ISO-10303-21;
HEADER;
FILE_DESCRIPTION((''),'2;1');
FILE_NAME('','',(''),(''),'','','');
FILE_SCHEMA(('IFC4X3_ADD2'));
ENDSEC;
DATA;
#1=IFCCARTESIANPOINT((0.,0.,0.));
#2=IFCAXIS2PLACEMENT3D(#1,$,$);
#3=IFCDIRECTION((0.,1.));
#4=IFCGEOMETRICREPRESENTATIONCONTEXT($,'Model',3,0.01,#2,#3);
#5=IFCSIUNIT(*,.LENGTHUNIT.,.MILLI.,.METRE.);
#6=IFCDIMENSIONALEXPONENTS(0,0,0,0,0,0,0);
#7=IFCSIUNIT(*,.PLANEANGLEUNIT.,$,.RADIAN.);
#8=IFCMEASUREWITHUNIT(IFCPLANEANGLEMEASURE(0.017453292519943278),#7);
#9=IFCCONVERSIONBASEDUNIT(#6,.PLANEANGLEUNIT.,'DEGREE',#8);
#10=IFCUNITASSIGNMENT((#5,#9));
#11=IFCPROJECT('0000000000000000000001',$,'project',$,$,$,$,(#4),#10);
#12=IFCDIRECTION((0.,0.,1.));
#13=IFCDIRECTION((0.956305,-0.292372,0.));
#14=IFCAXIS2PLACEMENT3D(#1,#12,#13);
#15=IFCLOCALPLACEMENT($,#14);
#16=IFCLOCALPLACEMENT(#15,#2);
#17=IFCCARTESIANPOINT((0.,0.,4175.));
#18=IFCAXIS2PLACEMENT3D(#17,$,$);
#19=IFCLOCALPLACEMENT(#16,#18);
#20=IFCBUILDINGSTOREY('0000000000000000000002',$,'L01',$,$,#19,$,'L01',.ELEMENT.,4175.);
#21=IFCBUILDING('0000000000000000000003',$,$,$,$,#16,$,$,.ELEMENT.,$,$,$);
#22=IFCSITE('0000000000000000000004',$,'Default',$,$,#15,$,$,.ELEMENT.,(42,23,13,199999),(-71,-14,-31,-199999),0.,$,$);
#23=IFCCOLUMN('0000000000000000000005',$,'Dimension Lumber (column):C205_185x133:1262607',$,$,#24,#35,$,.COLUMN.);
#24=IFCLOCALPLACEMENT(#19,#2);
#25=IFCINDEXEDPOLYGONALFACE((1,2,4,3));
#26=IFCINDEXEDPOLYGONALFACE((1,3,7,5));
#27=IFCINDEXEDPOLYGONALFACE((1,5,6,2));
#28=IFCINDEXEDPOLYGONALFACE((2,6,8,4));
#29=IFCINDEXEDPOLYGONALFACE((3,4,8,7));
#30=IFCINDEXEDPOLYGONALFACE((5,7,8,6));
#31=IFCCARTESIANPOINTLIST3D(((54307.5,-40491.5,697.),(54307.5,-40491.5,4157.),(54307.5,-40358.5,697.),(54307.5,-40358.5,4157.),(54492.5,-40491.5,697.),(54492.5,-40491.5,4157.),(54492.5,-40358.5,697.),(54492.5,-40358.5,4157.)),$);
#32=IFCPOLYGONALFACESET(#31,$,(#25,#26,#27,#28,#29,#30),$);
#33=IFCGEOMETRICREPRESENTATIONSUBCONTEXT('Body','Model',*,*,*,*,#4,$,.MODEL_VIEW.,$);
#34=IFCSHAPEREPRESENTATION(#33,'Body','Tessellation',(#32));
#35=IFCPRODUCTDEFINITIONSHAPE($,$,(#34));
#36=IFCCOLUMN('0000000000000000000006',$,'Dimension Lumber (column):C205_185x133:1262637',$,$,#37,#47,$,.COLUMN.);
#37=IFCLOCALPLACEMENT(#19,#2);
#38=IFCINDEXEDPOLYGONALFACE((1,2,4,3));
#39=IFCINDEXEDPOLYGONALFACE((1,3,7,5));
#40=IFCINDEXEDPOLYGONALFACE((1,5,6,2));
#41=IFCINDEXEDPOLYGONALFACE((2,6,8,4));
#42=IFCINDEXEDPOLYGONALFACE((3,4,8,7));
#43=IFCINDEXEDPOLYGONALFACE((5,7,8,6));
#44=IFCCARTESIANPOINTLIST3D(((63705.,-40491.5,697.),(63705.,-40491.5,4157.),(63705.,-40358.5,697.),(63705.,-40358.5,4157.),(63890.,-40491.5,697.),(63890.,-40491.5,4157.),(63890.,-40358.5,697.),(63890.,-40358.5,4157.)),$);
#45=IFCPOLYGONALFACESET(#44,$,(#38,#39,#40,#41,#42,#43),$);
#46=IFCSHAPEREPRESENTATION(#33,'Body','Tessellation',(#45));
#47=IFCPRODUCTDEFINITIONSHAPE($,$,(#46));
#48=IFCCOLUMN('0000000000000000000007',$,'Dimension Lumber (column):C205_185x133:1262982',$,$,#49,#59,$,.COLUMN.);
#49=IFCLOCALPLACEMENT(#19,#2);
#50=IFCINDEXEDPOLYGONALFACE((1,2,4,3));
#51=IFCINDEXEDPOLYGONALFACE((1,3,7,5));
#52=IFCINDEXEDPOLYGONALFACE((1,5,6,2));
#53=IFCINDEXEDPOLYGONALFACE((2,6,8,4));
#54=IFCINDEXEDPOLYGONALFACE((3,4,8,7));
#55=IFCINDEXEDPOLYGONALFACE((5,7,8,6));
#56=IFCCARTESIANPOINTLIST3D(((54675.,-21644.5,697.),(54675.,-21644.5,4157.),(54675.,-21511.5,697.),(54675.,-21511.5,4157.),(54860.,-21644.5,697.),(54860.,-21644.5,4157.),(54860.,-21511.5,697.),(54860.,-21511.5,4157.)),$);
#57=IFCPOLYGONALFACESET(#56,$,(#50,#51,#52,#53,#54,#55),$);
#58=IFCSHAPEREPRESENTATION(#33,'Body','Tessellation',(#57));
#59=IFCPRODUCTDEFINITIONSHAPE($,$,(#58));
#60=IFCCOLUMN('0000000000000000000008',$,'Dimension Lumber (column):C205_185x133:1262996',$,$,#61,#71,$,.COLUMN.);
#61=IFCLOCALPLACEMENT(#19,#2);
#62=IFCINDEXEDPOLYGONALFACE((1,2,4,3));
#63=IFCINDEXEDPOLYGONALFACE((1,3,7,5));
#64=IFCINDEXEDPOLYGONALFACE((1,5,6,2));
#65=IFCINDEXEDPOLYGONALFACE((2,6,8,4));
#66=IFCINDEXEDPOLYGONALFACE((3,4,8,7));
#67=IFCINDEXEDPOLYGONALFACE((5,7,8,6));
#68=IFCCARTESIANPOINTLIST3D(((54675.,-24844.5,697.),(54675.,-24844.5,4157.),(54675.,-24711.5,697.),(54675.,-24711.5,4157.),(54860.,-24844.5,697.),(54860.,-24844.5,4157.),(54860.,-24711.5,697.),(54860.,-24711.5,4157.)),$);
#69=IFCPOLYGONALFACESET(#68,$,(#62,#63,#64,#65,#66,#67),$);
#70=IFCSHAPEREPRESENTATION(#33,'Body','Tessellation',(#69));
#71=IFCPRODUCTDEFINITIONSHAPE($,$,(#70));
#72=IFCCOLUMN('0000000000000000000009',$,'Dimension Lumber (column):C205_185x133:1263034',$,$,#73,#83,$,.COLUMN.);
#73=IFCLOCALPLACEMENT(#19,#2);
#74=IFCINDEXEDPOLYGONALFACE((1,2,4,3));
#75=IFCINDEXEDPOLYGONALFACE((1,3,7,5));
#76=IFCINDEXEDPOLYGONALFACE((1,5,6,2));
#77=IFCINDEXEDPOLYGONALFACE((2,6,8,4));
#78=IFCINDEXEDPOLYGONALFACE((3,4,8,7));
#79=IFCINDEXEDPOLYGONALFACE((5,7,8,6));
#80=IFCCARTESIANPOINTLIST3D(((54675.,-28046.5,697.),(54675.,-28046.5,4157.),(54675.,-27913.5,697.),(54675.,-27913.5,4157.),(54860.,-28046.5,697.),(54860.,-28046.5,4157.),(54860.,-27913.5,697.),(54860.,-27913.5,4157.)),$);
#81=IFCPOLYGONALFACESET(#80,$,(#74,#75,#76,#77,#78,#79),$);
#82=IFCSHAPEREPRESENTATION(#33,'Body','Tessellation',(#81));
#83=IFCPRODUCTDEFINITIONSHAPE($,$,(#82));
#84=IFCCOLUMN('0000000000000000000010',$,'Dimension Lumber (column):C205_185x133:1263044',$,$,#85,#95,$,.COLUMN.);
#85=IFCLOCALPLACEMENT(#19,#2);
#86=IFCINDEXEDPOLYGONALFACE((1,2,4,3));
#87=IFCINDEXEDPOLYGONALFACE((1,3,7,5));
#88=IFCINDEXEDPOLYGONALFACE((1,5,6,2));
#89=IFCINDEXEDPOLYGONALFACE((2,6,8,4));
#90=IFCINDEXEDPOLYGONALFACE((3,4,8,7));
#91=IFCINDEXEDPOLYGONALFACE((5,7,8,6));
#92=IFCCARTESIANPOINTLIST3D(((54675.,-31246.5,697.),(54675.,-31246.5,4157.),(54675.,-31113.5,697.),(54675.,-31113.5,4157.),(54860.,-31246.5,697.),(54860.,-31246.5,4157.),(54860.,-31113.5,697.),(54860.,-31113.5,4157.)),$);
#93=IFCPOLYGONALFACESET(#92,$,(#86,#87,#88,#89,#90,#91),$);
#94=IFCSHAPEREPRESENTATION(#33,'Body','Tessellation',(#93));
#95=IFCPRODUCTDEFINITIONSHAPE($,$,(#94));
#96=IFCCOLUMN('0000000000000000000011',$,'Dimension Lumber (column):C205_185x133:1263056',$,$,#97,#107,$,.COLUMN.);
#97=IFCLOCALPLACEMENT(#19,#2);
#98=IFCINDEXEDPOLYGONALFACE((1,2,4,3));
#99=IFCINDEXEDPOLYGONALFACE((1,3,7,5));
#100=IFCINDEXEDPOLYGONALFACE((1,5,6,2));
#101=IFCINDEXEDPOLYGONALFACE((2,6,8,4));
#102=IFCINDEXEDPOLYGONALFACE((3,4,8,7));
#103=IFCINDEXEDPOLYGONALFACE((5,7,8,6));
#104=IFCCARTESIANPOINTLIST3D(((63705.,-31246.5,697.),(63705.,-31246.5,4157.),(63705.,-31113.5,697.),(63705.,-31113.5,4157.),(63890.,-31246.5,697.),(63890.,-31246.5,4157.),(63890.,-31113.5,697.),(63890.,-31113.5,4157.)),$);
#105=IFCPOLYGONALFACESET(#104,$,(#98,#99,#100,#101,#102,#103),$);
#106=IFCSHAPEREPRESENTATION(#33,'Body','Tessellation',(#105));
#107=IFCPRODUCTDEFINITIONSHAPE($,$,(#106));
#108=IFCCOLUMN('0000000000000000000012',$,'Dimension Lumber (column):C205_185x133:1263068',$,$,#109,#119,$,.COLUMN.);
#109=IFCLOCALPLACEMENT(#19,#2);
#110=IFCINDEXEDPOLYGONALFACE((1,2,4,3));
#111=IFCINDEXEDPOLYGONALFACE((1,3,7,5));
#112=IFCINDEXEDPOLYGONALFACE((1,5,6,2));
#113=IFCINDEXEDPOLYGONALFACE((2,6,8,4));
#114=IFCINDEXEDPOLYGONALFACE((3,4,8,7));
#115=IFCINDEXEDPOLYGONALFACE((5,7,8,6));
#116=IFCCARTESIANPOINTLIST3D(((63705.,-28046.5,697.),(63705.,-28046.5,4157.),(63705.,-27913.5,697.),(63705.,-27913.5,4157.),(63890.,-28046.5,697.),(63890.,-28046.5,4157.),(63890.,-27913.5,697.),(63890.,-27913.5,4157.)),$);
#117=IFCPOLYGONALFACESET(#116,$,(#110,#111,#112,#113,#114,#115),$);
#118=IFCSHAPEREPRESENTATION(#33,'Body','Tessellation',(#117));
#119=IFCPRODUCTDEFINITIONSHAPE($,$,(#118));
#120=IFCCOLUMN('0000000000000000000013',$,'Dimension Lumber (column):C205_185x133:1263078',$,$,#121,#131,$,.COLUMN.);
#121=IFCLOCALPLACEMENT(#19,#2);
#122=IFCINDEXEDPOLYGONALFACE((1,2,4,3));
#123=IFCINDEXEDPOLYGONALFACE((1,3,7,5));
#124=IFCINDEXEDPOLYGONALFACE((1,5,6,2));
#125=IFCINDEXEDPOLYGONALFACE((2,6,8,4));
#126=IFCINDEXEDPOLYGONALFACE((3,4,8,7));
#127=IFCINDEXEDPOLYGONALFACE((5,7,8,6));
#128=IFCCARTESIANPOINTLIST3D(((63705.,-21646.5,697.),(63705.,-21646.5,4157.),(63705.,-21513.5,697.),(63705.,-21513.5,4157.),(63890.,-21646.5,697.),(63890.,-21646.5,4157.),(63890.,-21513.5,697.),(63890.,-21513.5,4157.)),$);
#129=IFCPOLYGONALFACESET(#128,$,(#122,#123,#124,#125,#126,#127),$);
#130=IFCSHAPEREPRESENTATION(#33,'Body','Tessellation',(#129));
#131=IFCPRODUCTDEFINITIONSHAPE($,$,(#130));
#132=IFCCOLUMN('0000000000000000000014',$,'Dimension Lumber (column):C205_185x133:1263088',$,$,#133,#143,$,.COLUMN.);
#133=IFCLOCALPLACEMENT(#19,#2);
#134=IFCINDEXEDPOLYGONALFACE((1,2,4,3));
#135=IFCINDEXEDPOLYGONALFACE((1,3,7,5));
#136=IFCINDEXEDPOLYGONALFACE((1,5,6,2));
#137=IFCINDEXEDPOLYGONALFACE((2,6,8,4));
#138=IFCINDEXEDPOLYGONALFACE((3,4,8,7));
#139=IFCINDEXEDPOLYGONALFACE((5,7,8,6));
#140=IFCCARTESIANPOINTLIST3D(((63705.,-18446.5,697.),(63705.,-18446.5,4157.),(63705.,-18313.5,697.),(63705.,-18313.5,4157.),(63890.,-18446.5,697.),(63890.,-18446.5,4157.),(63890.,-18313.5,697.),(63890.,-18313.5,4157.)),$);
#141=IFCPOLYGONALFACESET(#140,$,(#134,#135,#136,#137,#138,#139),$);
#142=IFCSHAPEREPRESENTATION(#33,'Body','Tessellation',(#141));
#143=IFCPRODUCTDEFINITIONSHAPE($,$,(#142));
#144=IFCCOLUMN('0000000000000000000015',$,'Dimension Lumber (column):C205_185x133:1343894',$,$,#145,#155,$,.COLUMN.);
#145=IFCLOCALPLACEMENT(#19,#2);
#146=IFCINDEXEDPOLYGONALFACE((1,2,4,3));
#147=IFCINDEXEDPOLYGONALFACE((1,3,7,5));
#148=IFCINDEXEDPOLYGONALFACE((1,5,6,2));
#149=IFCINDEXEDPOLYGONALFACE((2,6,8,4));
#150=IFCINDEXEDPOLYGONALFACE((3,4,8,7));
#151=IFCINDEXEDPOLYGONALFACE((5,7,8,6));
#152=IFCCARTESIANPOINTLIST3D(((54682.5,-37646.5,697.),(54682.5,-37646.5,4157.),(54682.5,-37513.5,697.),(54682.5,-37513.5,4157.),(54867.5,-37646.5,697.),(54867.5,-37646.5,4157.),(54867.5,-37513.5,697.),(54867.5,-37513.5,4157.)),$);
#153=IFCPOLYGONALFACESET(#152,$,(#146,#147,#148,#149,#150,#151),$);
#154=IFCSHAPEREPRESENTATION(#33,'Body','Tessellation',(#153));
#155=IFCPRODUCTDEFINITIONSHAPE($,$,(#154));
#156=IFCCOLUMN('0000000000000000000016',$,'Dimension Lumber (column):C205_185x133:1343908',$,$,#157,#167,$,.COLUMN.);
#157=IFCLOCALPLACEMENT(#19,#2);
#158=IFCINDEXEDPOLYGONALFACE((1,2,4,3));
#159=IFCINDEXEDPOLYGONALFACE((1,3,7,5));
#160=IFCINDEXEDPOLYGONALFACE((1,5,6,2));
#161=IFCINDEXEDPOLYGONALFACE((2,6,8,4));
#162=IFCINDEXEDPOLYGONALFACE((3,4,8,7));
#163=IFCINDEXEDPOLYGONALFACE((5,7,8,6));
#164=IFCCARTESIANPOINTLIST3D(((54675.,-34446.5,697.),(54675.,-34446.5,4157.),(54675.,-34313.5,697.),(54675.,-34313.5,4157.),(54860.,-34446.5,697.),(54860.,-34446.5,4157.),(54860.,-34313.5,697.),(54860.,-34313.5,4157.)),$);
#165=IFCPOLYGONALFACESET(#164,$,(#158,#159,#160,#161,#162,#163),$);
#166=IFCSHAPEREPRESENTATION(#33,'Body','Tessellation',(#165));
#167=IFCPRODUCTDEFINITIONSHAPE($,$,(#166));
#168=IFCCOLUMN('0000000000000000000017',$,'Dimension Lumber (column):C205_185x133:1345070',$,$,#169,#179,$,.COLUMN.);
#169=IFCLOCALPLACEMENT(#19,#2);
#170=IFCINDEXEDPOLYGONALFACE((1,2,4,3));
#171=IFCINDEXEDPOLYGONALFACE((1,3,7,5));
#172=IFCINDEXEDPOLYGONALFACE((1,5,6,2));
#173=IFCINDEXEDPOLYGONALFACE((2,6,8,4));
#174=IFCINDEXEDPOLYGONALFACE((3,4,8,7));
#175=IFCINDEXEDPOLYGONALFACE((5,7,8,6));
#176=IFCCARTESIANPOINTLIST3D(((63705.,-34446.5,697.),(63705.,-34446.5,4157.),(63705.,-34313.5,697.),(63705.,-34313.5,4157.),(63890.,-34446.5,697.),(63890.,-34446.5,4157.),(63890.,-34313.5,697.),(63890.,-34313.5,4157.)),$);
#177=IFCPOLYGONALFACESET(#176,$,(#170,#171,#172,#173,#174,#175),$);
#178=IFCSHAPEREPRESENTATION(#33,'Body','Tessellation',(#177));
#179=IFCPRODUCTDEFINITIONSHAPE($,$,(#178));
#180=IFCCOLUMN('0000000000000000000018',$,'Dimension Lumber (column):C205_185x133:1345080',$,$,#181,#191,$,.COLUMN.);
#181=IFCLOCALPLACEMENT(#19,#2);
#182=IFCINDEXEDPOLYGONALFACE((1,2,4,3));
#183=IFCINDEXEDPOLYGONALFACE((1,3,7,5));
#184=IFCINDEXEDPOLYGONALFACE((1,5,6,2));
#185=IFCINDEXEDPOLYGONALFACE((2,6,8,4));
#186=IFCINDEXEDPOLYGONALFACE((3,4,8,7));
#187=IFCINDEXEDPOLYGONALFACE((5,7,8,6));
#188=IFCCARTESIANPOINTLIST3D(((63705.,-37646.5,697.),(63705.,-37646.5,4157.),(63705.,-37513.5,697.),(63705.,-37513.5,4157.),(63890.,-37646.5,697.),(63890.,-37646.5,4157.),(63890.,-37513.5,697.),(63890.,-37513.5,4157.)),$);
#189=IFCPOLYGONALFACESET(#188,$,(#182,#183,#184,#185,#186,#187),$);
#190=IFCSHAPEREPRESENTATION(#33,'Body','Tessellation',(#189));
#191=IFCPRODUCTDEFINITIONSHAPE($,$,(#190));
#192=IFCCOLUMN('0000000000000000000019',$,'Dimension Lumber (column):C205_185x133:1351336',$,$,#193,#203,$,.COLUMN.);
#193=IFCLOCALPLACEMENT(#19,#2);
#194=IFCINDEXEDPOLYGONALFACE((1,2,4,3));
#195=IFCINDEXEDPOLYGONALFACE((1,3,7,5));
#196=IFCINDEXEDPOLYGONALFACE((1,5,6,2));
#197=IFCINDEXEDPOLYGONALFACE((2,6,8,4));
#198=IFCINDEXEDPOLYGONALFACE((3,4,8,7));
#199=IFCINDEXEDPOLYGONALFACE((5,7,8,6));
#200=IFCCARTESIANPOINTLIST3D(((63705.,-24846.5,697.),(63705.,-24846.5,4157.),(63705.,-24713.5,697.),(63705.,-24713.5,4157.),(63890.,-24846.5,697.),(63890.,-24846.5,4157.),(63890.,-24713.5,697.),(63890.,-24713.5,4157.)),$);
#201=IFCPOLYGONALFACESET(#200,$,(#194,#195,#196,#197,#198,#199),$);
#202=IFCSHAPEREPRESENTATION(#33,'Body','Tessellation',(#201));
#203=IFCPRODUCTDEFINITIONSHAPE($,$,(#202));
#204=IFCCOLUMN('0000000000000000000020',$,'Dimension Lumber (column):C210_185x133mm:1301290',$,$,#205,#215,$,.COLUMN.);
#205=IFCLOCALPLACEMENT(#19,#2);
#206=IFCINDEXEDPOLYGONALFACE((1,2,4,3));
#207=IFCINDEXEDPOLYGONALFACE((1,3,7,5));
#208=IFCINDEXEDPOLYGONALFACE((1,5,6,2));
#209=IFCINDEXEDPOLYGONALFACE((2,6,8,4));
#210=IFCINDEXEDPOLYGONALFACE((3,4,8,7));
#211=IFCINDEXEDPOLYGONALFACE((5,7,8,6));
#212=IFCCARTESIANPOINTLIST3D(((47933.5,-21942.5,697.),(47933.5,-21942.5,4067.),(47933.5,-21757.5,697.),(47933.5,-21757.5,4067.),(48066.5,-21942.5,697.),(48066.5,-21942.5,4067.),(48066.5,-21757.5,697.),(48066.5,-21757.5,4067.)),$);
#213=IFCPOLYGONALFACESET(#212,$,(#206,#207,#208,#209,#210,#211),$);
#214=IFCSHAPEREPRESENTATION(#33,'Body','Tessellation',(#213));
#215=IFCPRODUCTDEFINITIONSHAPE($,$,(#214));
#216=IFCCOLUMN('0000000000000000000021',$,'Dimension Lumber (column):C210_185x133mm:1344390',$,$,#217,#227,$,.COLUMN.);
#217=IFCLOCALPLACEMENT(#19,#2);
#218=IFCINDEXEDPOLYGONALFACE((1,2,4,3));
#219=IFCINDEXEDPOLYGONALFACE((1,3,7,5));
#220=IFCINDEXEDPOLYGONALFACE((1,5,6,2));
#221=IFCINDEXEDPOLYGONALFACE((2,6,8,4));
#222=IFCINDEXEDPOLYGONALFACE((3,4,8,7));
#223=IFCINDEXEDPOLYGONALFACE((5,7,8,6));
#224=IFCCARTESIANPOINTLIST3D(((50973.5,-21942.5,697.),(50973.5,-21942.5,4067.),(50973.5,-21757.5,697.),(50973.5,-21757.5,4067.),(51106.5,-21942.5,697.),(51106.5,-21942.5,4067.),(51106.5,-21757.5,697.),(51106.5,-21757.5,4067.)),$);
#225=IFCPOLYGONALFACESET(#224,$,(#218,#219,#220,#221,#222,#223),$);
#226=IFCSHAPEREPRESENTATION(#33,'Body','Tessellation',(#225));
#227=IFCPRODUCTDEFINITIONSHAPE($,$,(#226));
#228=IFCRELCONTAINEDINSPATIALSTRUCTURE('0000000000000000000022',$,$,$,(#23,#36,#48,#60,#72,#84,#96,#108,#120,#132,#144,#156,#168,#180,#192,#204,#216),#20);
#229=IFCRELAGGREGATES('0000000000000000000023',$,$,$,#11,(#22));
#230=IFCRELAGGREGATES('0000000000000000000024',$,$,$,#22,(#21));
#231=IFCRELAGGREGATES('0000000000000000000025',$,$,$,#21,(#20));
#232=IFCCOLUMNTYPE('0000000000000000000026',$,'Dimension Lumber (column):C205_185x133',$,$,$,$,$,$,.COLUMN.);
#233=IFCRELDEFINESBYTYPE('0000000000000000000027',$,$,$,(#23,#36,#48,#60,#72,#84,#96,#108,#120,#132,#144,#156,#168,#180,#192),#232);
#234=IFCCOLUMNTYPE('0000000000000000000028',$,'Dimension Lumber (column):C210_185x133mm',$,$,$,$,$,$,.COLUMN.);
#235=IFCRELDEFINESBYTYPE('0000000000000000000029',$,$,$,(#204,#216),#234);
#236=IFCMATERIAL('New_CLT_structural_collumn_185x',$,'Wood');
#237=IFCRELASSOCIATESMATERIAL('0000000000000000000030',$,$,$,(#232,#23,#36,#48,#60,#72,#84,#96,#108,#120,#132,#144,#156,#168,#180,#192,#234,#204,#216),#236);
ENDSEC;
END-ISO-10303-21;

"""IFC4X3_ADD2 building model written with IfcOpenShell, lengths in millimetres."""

from ifc_helpers import new_model, entity, si_unit, converted_unit, direction, frame, origin, origin_2d_with_axis, place, context, subcontext, project, spatial, rectangle, extrude, source, transform, mapped, material, material_profile, profile_set, profile_usage, type_object, type_shapes, element, save


model = new_model("IFC4X3_ADD2")

# Units and contexts
model_context = context("Model", 3, precision=0.01, world=origin(), true_north=direction((0.0, 1.0)))
body_context = subcontext(model_context, "Body", "Model", "MODEL_VIEW")
ifc_project = project(units=[si_unit("LENGTHUNIT", "METRE", prefix="MILLI"), converted_unit("PLANEANGLEUNIT", "DEGREE", entity("IfcPlaneAngleMeasure", 0.017453292519943278), si_unit("PLANEANGLEUNIT", "RADIAN"), dimensions=[0, 0, 0, 0, 0, 0, 0])], contexts=[model_context])

# Site, building, storey
site_placement = place(None, frame((0.0, 0.0, 0.0), z_axis=(0.0, 0.0, 1.0), x_axis=(0.956305, -0.292372, 0.0)))
site = spatial("IfcSite", under=ifc_project, at=site_placement, Name="Default", CompositionType="ELEMENT", RefLatitude=(42, 23, 13, 199999), RefLongitude=(-71, -14, -31, -199999), RefElevation=0.0)
building_placement = place(site_placement, origin())
building = spatial("IfcBuilding", under=site, at=building_placement, CompositionType="ELEMENT")
storey_placement = place(building_placement, frame((0.0, 0.0, 4175.0)))
storey = spatial("IfcBuildingStorey", under=building, at=storey_placement, Name="L01", LongName="L01", CompositionType="ELEMENT", Elevation=4175.0)

# Columns
ifc_material_1 = material(Name="New_CLT_structural_collumn_185x", Category="Wood")
ifc_material_profile_1 = material_profile(ifc_material_1, rectangle(XDim=185.0, YDim=133.0, at=origin_2d_with_axis()), Name="C205_185x133")
ifc_profile_set_1 = profile_set([ifc_material_profile_1], Name="C205_185x133")
ifc_profile_usage_1 = profile_usage(ifc_profile_set_1)
column_type_1 = type_object("IfcColumnType", Name="Dimension Lumber (column):C205_185x133", PredefinedType="COLUMN", material=ifc_profile_set_1)
shared_shape_1 = source(origin(), body_context, "Body", "SweptSolid", [
    extrude(rectangle(XDim=185.0, YDim=133.0, at=origin_2d_with_axis()), frame((0.0, 0.0, 4872.0), z_axis=(0.0, 0.0, 1.0), x_axis=(-1.0, 0.0, 0.0)), (0.0, 0.0, 1.0), 3460.0),
])
type_shapes(column_type_1, [shared_shape_1])
for number, where, z_axis, x_axis, name in (
    (1, (54400.0, -40425.0, -4175.0), (0.0, 0.0, 1.0), (-1.0, 0.0, 0.0), "Dimension Lumber (column):C205_185x133:1262607"),
    (2, (63797.5, -40425.0, -4175.0), (0.0, 0.0, 1.0), (-1.0, 0.0, 0.0), "Dimension Lumber (column):C205_185x133:1262637"),
):
    element("IfcColumn", number, at=place(storey_placement, frame(where, z_axis=z_axis, x_axis=x_axis)), inside=storey, type_object=column_type_1, material=ifc_profile_usage_1, Name=name, PredefinedType="COLUMN", context=body_context, shape_type="MappedRepresentation", body=[
        mapped(shared_shape_1, transform((0.0, 0.0, 0.0), scale=1.0)),
    ])
for number, where, name in (
    (3, (54767.5, -21578.0, -4175.0), "Dimension Lumber (column):C205_185x133:1262982"),
    (4, (54767.5, -24778.0, -4175.0), "Dimension Lumber (column):C205_185x133:1262996"),
    (5, (54767.5, -27980.0, -4175.0), "Dimension Lumber (column):C205_185x133:1263034"),
    (6, (54767.5, -31180.0, -4175.0), "Dimension Lumber (column):C205_185x133:1263044"),
    (7, (63797.5, -31180.0, -4175.0), "Dimension Lumber (column):C205_185x133:1263056"),
    (8, (63797.5, -27980.0, -4175.0), "Dimension Lumber (column):C205_185x133:1263068"),
    (9, (63797.5, -21580.0, -4175.0), "Dimension Lumber (column):C205_185x133:1263078"),
    (10, (63797.5, -18380.0, -4175.0), "Dimension Lumber (column):C205_185x133:1263088"),
):
    element("IfcColumn", number, at=place(storey_placement, frame(where)), inside=storey, type_object=column_type_1, material=ifc_profile_usage_1, Name=name, PredefinedType="COLUMN", context=body_context, shape_type="MappedRepresentation", body=[
        mapped(shared_shape_1, transform((0.0, 0.0, 0.0), scale=1.0)),
    ])
for number, where, z_axis, x_axis, name in (
    (11, (54775.0, -37580.0, -4175.0), (0.0, 0.0, 1.0), (-1.0, 0.0, 0.0), "Dimension Lumber (column):C205_185x133:1343894"),
    (12, (54767.5, -34380.0, -4175.0), (0.0, 0.0, 1.0), (-1.0, 0.0, 0.0), "Dimension Lumber (column):C205_185x133:1343908"),
):
    element("IfcColumn", number, at=place(storey_placement, frame(where, z_axis=z_axis, x_axis=x_axis)), inside=storey, type_object=column_type_1, material=ifc_profile_usage_1, Name=name, PredefinedType="COLUMN", context=body_context, shape_type="MappedRepresentation", body=[
        mapped(shared_shape_1, transform((0.0, 0.0, 0.0), scale=1.0)),
    ])
for number, where, name in (
    (13, (63797.5, -34380.0, -4175.0), "Dimension Lumber (column):C205_185x133:1345070"),
    (14, (63797.5, -37580.0, -4175.0), "Dimension Lumber (column):C205_185x133:1345080"),
    (15, (63797.5, -24780.0, -4175.0), "Dimension Lumber (column):C205_185x133:1351336"),
):
    element("IfcColumn", number, at=place(storey_placement, frame(where)), inside=storey, type_object=column_type_1, material=ifc_profile_usage_1, Name=name, PredefinedType="COLUMN", context=body_context, shape_type="MappedRepresentation", body=[
        mapped(shared_shape_1, transform((0.0, 0.0, 0.0), scale=1.0)),
    ])
ifc_material_profile_2 = material_profile(ifc_material_1, rectangle(XDim=185.0, YDim=133.0, at=origin_2d_with_axis()), Name="C210_185x133mm")
ifc_profile_set_2 = profile_set([ifc_material_profile_2], Name="C210_185x133mm")
ifc_profile_usage_2 = profile_usage(ifc_profile_set_2)
column_type_2 = type_object("IfcColumnType", Name="Dimension Lumber (column):C210_185x133mm", PredefinedType="COLUMN", material=ifc_profile_set_2)
shared_shape_2 = source(origin(), body_context, "Body", "SweptSolid", [
    extrude(rectangle(XDim=185.0, YDim=133.0, at=origin_2d_with_axis()), frame((0.0, 0.0, 4872.0), z_axis=(0.0, 0.0, 1.0), x_axis=(-1.0, 0.0, 0.0)), (0.0, 0.0, 1.0), 3370.0),
])
type_shapes(column_type_2, [shared_shape_2])
for number, where, z_axis, x_axis, name in (
    (16, (48000.0, -21850.0, -4175.0), (0.0, 0.0, 1.0), (0.0, 1.0, 0.0), "Dimension Lumber (column):C210_185x133mm:1301290"),
    (17, (51040.0, -21850.0, -4175.0), (0.0, 0.0, 1.0), (0.0, 1.0, 0.0), "Dimension Lumber (column):C210_185x133mm:1344390"),
):
    element("IfcColumn", number, at=place(storey_placement, frame(where, z_axis=z_axis, x_axis=x_axis)), inside=storey, type_object=column_type_2, material=ifc_profile_usage_2, Name=name, PredefinedType="COLUMN", context=body_context, shape_type="MappedRepresentation", body=[
        mapped(shared_shape_2, transform((0.0, 0.0, 0.0), scale=1.0)),
    ])

save(model, "model.ifc")
